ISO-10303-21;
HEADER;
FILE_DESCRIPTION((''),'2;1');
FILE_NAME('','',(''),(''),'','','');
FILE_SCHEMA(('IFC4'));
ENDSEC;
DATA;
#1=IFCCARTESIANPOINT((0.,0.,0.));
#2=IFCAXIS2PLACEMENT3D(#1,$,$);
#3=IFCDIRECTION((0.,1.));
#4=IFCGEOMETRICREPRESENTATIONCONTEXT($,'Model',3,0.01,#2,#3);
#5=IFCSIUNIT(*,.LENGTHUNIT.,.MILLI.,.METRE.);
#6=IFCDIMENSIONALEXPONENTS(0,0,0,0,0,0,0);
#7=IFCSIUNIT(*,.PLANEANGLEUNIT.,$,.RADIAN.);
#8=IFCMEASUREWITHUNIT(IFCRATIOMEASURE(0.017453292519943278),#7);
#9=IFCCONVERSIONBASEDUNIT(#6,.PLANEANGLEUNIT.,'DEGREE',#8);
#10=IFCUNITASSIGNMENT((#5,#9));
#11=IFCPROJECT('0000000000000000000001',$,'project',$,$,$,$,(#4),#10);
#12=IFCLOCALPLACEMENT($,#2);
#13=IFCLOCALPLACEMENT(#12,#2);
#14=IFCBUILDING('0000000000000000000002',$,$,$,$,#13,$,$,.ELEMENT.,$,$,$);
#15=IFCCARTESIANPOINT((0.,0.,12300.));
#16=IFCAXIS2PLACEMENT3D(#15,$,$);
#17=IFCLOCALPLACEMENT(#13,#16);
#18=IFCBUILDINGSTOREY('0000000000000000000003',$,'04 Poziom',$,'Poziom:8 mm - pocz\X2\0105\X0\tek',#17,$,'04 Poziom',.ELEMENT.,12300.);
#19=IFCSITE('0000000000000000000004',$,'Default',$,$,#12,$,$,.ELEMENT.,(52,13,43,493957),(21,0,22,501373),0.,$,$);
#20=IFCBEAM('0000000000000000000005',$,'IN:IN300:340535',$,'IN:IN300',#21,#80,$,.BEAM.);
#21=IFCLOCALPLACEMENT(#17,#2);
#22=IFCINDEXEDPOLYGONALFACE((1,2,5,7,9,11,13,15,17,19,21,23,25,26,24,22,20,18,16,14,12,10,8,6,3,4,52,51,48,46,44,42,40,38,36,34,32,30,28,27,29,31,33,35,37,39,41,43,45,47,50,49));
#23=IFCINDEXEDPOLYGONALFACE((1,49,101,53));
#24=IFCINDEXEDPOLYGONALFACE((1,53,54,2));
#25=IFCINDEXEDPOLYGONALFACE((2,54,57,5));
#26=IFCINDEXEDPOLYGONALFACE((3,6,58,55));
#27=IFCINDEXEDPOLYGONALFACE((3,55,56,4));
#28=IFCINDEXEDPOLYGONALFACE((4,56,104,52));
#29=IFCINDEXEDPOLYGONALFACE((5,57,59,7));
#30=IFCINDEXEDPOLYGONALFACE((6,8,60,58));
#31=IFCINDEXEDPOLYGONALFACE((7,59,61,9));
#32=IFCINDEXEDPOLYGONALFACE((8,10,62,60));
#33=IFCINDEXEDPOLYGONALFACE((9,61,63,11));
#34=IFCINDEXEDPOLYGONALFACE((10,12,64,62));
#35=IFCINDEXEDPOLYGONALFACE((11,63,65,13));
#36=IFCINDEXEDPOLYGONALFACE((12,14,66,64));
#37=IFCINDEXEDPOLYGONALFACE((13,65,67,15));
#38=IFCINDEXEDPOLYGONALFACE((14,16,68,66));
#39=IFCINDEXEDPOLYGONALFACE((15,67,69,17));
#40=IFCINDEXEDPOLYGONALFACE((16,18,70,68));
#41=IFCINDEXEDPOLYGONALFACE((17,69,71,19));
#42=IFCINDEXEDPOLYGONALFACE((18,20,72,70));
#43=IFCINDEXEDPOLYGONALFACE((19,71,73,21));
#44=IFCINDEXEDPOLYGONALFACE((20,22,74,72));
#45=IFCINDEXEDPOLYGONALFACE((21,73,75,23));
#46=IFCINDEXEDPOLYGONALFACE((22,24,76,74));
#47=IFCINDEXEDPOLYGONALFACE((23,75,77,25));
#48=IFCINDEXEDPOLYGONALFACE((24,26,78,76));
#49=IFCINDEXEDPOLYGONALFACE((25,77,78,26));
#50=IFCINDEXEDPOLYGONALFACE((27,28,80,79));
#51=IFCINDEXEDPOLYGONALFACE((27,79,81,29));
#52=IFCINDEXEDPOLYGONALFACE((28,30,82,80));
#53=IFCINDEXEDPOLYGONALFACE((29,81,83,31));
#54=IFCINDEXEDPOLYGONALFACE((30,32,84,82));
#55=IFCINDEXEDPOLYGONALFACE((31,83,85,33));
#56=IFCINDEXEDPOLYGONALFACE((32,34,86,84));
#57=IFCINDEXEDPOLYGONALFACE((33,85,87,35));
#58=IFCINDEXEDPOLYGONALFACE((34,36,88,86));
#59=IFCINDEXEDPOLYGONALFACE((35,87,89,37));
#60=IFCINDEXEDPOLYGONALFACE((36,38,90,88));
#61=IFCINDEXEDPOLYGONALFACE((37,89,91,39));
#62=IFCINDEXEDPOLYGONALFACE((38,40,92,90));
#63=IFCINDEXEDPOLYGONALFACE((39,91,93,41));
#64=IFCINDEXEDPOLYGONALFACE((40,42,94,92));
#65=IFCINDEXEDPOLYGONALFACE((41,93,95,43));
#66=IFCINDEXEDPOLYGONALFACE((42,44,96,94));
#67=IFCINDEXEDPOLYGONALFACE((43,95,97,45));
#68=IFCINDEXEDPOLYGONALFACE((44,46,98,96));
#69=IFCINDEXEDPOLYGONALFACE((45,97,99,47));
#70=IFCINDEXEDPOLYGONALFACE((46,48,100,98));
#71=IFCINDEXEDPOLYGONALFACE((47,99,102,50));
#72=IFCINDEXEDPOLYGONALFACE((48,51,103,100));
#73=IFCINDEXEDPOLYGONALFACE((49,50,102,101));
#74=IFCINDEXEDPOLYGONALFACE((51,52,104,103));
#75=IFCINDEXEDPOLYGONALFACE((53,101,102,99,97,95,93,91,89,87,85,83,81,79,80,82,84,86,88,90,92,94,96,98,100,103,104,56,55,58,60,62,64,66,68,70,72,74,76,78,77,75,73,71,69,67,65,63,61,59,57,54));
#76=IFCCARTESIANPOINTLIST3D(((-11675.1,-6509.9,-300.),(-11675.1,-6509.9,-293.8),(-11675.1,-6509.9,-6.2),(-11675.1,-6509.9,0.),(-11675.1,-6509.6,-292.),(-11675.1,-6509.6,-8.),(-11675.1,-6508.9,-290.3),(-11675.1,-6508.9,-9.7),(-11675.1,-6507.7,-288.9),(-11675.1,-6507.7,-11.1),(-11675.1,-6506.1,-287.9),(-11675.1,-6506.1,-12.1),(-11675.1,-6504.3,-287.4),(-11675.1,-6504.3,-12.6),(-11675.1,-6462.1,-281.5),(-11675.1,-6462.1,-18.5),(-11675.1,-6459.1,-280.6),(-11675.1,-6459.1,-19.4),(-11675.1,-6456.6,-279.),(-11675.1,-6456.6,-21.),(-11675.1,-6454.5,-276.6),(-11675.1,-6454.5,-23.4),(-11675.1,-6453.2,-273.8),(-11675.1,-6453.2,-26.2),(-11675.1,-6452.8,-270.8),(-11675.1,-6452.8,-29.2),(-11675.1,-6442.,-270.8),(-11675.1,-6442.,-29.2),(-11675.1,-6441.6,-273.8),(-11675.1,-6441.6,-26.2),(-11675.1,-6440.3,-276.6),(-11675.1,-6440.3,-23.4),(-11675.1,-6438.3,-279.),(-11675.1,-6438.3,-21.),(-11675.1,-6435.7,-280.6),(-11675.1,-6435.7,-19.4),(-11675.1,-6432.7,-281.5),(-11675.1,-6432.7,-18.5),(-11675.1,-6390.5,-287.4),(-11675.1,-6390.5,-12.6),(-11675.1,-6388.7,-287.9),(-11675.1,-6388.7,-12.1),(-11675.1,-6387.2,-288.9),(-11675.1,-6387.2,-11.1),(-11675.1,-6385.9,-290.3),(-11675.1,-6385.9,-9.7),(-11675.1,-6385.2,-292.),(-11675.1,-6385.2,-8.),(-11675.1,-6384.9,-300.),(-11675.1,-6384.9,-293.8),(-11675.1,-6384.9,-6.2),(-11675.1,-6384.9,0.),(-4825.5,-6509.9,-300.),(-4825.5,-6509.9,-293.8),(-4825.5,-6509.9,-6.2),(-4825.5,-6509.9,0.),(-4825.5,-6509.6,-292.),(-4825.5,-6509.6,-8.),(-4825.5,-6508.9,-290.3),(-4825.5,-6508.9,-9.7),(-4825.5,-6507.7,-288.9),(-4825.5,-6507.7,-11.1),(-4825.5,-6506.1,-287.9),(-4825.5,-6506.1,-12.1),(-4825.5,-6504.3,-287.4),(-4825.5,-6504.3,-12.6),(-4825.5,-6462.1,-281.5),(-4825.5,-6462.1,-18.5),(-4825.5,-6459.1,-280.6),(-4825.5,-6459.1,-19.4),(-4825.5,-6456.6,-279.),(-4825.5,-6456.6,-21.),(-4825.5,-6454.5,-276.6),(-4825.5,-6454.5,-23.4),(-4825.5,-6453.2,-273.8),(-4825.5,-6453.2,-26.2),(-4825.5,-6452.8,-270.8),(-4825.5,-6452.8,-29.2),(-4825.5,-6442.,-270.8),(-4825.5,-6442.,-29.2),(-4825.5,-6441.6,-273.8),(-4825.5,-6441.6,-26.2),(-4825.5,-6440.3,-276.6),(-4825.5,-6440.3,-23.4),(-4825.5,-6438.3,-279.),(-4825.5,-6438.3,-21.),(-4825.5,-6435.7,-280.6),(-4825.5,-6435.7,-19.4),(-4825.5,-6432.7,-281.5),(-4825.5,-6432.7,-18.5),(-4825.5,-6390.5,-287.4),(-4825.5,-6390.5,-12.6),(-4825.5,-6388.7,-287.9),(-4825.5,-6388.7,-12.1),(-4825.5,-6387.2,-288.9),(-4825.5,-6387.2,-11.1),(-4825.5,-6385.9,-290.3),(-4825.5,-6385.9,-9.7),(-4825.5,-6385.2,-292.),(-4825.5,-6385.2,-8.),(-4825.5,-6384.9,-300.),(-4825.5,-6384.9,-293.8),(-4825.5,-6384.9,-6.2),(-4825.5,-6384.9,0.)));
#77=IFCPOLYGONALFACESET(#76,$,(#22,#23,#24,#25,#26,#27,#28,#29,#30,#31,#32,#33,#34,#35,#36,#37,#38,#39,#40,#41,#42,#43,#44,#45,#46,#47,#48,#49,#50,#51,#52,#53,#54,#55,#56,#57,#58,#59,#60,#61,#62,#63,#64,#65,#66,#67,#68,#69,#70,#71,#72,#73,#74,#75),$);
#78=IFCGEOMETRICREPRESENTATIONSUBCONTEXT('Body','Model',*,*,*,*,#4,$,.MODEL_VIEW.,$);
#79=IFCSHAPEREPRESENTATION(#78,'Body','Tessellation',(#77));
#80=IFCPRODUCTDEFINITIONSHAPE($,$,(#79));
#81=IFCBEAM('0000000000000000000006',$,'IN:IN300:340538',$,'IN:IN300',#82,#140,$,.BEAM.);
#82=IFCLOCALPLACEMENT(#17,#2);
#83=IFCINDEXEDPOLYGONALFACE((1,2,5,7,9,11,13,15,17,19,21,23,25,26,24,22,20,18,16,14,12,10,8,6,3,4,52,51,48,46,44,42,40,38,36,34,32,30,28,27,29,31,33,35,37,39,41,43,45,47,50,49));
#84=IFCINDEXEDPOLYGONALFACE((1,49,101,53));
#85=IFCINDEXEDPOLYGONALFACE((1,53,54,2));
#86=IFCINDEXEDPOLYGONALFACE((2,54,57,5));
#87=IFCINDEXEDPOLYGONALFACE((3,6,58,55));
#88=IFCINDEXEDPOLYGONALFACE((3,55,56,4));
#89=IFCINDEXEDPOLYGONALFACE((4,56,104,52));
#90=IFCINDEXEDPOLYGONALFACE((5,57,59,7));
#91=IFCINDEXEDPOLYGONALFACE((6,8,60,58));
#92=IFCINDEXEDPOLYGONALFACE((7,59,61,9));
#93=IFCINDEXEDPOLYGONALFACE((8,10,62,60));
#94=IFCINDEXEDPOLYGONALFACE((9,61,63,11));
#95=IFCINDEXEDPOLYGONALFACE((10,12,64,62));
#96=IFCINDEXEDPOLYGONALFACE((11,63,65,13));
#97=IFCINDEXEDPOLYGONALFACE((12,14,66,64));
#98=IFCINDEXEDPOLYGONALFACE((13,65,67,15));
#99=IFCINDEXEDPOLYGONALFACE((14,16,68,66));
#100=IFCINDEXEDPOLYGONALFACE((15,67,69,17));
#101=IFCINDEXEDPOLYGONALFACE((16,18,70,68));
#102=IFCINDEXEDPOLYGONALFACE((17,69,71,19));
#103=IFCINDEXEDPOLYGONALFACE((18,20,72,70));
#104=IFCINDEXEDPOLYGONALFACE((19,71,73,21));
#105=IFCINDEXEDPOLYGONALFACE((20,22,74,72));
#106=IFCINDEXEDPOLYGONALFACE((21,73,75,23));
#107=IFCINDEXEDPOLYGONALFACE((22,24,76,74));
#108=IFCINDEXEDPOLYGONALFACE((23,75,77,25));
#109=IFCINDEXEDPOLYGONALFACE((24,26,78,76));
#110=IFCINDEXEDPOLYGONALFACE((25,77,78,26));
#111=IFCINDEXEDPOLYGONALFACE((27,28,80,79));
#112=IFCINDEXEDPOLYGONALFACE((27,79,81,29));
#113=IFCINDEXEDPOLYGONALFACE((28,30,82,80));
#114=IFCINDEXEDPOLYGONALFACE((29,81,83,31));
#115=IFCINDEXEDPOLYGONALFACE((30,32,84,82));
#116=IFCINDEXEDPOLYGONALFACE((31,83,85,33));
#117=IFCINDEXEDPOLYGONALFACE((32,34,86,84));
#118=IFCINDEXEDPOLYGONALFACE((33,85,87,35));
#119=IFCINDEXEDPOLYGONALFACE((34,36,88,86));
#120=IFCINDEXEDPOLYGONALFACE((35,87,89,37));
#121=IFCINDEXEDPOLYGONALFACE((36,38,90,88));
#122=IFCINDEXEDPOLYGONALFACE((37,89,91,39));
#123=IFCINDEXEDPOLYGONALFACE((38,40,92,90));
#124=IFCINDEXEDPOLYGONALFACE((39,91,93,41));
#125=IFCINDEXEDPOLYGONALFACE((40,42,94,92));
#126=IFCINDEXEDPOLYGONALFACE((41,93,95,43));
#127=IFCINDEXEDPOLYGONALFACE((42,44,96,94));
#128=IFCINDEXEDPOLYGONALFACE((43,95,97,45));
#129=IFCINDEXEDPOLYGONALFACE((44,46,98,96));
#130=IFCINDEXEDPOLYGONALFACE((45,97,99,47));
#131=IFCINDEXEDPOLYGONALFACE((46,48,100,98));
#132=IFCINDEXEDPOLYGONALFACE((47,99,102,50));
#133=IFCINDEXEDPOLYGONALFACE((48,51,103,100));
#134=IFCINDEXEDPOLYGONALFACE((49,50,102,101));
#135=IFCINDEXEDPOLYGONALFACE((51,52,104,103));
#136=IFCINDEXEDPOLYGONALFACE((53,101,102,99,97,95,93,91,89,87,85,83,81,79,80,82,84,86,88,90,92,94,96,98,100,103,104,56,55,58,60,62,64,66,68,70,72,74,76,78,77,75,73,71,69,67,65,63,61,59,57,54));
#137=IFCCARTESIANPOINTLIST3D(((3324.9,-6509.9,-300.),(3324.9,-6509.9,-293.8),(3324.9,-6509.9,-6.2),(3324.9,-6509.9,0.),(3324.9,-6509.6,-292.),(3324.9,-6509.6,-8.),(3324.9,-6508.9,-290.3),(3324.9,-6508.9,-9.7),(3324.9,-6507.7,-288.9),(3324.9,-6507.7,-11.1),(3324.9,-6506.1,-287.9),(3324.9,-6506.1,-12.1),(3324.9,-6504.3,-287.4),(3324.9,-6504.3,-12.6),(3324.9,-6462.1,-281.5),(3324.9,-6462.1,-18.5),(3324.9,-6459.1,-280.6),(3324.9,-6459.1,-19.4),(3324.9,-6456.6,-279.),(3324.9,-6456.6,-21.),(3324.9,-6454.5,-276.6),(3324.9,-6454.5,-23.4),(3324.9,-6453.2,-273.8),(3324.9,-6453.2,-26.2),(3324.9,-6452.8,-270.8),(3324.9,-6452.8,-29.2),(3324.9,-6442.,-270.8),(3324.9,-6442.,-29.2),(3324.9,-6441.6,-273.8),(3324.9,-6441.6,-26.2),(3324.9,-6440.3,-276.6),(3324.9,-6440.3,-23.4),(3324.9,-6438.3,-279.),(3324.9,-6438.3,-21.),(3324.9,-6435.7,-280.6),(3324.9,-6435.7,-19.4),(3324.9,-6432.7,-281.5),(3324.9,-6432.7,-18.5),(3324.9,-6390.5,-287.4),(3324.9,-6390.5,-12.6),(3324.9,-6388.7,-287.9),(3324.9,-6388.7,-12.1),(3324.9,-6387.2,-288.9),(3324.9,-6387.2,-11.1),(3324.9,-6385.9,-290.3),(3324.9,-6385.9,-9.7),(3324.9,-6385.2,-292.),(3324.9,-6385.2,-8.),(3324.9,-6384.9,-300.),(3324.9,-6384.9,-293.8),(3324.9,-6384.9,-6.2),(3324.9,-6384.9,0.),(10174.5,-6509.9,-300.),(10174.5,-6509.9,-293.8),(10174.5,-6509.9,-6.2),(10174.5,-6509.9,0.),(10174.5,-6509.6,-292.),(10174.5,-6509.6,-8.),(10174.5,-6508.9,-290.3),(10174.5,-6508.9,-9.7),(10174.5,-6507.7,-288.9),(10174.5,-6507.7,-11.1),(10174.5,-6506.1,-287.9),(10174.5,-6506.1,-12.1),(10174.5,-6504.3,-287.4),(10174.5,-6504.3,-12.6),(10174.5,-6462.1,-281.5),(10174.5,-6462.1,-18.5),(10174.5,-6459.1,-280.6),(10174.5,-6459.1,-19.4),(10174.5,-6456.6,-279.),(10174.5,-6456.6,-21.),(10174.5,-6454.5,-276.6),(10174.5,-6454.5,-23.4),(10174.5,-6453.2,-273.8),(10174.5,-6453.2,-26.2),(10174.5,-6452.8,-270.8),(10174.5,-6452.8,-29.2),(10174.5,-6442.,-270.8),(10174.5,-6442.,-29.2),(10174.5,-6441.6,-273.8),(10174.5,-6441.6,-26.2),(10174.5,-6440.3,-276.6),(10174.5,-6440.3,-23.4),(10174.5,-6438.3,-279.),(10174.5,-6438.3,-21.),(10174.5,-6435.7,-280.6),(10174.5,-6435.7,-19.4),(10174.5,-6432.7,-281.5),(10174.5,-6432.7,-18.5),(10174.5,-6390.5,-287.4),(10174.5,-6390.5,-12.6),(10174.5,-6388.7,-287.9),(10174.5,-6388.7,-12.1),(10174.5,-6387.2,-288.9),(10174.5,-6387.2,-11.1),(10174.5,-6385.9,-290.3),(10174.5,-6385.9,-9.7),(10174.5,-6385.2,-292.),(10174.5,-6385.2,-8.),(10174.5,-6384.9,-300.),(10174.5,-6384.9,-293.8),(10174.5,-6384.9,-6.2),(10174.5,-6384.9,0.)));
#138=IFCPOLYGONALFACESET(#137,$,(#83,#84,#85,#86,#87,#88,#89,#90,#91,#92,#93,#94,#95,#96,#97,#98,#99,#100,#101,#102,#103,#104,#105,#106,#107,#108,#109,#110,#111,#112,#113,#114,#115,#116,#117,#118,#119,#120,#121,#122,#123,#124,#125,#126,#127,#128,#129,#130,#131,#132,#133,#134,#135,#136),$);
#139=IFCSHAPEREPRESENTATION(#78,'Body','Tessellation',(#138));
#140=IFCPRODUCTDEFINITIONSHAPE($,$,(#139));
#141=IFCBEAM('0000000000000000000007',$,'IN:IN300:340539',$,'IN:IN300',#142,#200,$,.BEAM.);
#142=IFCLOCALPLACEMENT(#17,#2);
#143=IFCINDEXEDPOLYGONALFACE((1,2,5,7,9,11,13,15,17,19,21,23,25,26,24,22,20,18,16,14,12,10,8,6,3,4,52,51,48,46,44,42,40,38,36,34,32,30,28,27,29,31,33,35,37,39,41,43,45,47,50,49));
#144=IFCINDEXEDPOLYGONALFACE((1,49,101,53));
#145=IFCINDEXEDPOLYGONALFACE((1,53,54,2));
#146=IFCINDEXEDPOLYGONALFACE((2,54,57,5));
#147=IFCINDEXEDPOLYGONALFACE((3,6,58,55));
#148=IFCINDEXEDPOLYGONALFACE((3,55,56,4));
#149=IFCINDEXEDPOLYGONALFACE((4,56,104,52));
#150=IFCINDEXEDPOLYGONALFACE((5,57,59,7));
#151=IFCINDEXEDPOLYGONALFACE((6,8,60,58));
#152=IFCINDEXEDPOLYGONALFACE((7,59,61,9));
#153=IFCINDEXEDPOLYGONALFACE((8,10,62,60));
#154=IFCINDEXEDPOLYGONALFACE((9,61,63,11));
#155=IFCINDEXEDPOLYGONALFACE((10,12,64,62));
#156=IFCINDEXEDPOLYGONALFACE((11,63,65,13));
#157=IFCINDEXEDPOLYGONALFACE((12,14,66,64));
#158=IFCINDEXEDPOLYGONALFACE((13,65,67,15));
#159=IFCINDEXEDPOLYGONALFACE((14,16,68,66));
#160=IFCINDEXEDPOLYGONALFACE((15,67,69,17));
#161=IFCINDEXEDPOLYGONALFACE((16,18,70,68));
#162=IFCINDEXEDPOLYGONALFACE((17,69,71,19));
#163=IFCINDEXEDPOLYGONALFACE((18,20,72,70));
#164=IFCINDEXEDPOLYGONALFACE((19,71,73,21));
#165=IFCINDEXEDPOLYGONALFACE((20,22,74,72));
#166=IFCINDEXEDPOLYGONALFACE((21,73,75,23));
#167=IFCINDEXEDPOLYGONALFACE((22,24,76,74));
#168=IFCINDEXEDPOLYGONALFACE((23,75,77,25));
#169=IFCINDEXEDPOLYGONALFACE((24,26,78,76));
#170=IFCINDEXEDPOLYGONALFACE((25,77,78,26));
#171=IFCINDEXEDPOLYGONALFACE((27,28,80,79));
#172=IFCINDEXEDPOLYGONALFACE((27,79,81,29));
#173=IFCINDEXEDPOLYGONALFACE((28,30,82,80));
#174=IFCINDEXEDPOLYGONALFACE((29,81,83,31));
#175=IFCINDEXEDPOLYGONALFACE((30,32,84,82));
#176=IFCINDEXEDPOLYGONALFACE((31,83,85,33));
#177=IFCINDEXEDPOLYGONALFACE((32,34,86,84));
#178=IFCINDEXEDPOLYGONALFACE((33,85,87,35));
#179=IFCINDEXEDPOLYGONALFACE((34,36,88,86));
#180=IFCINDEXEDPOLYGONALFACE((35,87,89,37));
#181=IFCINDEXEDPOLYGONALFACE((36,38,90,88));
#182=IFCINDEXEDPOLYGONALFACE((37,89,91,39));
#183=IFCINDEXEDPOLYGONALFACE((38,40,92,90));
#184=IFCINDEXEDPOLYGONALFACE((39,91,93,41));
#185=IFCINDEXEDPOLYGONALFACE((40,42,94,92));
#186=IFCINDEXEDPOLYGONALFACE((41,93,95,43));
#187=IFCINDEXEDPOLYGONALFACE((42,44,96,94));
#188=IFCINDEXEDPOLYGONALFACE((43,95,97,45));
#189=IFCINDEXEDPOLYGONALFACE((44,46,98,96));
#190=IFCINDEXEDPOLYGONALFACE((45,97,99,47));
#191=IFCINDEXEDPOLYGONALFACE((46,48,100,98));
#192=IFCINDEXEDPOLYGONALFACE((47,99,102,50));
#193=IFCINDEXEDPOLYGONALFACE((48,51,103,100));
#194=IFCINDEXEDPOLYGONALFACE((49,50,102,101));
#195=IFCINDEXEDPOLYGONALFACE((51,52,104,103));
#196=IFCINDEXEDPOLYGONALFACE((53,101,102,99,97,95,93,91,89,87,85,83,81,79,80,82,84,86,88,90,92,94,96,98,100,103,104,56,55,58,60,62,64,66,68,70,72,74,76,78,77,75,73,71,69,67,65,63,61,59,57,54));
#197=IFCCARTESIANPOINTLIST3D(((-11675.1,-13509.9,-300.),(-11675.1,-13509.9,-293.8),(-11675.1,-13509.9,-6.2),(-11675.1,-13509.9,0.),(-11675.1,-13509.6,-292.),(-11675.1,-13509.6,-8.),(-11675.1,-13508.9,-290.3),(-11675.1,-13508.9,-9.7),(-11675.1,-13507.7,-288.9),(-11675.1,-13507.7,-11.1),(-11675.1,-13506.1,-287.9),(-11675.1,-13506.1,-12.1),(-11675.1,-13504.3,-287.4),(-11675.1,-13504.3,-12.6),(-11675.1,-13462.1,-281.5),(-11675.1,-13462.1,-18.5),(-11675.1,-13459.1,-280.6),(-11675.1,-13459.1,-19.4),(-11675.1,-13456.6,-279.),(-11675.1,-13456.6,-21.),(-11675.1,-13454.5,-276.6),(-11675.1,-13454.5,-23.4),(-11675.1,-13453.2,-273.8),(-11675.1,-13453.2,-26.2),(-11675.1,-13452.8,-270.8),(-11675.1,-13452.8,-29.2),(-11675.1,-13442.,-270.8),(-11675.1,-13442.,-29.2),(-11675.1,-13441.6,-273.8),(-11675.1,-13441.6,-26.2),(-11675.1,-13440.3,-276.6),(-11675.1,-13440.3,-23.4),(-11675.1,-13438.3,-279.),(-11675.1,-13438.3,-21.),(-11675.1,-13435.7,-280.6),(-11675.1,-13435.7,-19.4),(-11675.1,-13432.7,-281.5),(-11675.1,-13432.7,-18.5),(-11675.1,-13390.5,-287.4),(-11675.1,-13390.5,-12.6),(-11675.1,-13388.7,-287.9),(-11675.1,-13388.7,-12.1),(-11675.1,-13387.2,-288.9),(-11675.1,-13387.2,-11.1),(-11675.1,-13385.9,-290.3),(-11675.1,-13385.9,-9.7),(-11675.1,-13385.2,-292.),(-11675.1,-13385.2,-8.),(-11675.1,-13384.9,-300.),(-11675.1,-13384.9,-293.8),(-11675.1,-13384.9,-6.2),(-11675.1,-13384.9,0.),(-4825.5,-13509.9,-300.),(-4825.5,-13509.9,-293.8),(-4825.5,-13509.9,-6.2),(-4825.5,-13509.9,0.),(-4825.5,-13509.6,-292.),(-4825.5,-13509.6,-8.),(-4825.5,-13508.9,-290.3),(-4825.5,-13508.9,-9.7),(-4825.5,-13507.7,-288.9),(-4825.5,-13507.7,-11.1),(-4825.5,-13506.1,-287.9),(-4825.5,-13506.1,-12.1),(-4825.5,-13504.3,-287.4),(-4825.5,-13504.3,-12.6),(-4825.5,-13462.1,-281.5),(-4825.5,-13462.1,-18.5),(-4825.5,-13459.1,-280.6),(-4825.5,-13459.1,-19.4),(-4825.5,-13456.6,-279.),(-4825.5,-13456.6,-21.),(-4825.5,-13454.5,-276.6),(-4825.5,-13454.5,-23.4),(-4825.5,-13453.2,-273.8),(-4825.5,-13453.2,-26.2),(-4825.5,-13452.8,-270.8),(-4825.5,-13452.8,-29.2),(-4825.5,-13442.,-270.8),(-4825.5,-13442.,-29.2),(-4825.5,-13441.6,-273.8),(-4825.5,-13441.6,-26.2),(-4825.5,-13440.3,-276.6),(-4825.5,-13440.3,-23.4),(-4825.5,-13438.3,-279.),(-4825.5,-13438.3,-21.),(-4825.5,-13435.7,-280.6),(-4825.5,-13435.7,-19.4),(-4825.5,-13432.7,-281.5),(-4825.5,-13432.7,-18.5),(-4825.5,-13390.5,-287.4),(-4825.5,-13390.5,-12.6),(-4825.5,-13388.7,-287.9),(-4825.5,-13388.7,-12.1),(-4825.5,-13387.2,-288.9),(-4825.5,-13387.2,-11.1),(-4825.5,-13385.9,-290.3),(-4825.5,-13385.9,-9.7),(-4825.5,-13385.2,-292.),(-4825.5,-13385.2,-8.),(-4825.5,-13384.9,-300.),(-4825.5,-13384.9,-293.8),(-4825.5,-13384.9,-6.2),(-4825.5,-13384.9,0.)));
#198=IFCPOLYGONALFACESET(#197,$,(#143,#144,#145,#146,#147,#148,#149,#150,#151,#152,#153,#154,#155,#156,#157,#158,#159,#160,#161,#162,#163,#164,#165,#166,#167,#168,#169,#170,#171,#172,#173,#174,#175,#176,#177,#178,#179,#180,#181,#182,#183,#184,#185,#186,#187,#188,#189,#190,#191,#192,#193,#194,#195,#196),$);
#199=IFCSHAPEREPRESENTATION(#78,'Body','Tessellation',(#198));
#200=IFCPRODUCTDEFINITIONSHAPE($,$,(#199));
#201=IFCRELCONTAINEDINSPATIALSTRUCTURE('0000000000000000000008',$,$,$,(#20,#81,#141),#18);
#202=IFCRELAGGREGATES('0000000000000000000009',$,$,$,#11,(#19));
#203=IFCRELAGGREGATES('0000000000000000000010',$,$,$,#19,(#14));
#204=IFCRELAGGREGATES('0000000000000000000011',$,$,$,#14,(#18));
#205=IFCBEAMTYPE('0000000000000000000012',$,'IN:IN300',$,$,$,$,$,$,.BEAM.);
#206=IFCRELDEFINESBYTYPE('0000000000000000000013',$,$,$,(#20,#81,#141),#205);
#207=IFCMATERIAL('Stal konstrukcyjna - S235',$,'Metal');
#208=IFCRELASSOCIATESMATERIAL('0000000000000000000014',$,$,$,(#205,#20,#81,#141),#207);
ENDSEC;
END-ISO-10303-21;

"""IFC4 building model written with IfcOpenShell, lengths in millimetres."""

from ifc_helpers import new_model, entity, si_unit, converted_unit, direction, frame, origin, place, context, subcontext, project, spatial, line, arc, indexed_curve, outline, extrude, source, transform, mapped, material, type_object, type_shapes, element, save


model = new_model("IFC4")

# Units and contexts
model_context = context("Model", 3, precision=0.01, world=origin(), true_north=direction((0.0, 1.0)))
body_context = subcontext(model_context, "Body", "Model", "MODEL_VIEW")
ifc_project = project(units=[si_unit("LENGTHUNIT", "METRE", prefix="MILLI"), converted_unit("PLANEANGLEUNIT", "DEGREE", entity("IfcRatioMeasure", 0.017453292519943278), si_unit("PLANEANGLEUNIT", "RADIAN"), dimensions=[0, 0, 0, 0, 0, 0, 0])], contexts=[model_context])

# Site, building, storey
site_placement = place(None, origin())
site = spatial("IfcSite", under=ifc_project, at=site_placement, Name="Default", CompositionType="ELEMENT", RefLatitude=(52, 13, 43, 493957), RefLongitude=(21, 0, 22, 501373), RefElevation=0.0)
building_placement = place(site_placement, origin())
building = spatial("IfcBuilding", under=site, at=building_placement, CompositionType="ELEMENT")
storey_placement = place(building_placement, frame((0.0, 0.0, 12300.0)))
storey = spatial("IfcBuildingStorey", under=building, at=storey_placement, Name="04 Poziom", ObjectType="Poziom:8 mm - początek", LongName="04 Poziom", CompositionType="ELEMENT", Elevation=12300.0)

# Shared definitions
ifc_material = material(Name="Stal konstrukcyjna - S235", Category="Metal")

# Beams
beam_type_1 = type_object("IfcBeamType", Name="IN:IN300", PredefinedType="BEAM", material=ifc_material)
shared_shape_1 = source(origin(), body_context, "Body", "SweptSolid", [
    extrude(outline(indexed_curve([(143.8, -62.5), (150.0, -62.5), (150.0, 62.5), (143.8, 62.5), (139.6, 60.9), (137.4, 56.9), (131.5, 14.7), (127.9, 8.1), (120.8, 5.4), (-120.8, 5.4), (-127.9, 8.1), (-131.5, 14.7), (-137.4, 56.9), (-139.6, 60.9), (-143.8, 62.5), (-150.0, 62.5), (-150.0, -62.5), (-143.8, -62.5), (-139.6, -60.9), (-137.4, -56.9), (-131.5, -14.7), (-127.9, -8.1), (-120.8, -5.4), (120.8, -5.4), (127.9, -8.1), (131.5, -14.7), (137.4, -56.9), (139.6, -60.9)], segments=[line(1, 2, 3, 4), arc(4, 5, 6), line(6, 7), arc(7, 8, 9), line(9, 10), arc(10, 11, 12), line(12, 13), arc(13, 14, 15), line(15, 16, 17, 18), arc(18, 19, 20), line(20, 21), arc(21, 22, 23), line(23, 24), arc(24, 25, 26), line(26, 27), arc(27, 28, 1)], self_intersect=False)), frame((-3424.8, 0.0, 0.0), z_axis=(1.0, 0.0, 0.0), x_axis=(0.0, 0.0, -1.0)), (0.0, 0.0, 1.0), 6849.6),
])
type_shapes(beam_type_1, [shared_shape_1])
for number, where, name in (
    (1, (-8250.3, -6447.4, -150.0), "IN:IN300:340535"),
    (2, (6749.7, -6447.4, -150.0), "IN:IN300:340538"),
    (3, (-8250.3, -13447.4, -150.0), "IN:IN300:340539"),
):
    element("IfcBeam", number, at=place(storey_placement, frame(where)), inside=storey, type_object=beam_type_1, material=ifc_material, Name=name, ObjectType="IN:IN300", PredefinedType="BEAM", context=body_context, shape_type="MappedRepresentation", body=[
        mapped(shared_shape_1, transform((0.0, 0.0, 0.0), scale=1.0)),
    ])

save(model, "model.ifc")
